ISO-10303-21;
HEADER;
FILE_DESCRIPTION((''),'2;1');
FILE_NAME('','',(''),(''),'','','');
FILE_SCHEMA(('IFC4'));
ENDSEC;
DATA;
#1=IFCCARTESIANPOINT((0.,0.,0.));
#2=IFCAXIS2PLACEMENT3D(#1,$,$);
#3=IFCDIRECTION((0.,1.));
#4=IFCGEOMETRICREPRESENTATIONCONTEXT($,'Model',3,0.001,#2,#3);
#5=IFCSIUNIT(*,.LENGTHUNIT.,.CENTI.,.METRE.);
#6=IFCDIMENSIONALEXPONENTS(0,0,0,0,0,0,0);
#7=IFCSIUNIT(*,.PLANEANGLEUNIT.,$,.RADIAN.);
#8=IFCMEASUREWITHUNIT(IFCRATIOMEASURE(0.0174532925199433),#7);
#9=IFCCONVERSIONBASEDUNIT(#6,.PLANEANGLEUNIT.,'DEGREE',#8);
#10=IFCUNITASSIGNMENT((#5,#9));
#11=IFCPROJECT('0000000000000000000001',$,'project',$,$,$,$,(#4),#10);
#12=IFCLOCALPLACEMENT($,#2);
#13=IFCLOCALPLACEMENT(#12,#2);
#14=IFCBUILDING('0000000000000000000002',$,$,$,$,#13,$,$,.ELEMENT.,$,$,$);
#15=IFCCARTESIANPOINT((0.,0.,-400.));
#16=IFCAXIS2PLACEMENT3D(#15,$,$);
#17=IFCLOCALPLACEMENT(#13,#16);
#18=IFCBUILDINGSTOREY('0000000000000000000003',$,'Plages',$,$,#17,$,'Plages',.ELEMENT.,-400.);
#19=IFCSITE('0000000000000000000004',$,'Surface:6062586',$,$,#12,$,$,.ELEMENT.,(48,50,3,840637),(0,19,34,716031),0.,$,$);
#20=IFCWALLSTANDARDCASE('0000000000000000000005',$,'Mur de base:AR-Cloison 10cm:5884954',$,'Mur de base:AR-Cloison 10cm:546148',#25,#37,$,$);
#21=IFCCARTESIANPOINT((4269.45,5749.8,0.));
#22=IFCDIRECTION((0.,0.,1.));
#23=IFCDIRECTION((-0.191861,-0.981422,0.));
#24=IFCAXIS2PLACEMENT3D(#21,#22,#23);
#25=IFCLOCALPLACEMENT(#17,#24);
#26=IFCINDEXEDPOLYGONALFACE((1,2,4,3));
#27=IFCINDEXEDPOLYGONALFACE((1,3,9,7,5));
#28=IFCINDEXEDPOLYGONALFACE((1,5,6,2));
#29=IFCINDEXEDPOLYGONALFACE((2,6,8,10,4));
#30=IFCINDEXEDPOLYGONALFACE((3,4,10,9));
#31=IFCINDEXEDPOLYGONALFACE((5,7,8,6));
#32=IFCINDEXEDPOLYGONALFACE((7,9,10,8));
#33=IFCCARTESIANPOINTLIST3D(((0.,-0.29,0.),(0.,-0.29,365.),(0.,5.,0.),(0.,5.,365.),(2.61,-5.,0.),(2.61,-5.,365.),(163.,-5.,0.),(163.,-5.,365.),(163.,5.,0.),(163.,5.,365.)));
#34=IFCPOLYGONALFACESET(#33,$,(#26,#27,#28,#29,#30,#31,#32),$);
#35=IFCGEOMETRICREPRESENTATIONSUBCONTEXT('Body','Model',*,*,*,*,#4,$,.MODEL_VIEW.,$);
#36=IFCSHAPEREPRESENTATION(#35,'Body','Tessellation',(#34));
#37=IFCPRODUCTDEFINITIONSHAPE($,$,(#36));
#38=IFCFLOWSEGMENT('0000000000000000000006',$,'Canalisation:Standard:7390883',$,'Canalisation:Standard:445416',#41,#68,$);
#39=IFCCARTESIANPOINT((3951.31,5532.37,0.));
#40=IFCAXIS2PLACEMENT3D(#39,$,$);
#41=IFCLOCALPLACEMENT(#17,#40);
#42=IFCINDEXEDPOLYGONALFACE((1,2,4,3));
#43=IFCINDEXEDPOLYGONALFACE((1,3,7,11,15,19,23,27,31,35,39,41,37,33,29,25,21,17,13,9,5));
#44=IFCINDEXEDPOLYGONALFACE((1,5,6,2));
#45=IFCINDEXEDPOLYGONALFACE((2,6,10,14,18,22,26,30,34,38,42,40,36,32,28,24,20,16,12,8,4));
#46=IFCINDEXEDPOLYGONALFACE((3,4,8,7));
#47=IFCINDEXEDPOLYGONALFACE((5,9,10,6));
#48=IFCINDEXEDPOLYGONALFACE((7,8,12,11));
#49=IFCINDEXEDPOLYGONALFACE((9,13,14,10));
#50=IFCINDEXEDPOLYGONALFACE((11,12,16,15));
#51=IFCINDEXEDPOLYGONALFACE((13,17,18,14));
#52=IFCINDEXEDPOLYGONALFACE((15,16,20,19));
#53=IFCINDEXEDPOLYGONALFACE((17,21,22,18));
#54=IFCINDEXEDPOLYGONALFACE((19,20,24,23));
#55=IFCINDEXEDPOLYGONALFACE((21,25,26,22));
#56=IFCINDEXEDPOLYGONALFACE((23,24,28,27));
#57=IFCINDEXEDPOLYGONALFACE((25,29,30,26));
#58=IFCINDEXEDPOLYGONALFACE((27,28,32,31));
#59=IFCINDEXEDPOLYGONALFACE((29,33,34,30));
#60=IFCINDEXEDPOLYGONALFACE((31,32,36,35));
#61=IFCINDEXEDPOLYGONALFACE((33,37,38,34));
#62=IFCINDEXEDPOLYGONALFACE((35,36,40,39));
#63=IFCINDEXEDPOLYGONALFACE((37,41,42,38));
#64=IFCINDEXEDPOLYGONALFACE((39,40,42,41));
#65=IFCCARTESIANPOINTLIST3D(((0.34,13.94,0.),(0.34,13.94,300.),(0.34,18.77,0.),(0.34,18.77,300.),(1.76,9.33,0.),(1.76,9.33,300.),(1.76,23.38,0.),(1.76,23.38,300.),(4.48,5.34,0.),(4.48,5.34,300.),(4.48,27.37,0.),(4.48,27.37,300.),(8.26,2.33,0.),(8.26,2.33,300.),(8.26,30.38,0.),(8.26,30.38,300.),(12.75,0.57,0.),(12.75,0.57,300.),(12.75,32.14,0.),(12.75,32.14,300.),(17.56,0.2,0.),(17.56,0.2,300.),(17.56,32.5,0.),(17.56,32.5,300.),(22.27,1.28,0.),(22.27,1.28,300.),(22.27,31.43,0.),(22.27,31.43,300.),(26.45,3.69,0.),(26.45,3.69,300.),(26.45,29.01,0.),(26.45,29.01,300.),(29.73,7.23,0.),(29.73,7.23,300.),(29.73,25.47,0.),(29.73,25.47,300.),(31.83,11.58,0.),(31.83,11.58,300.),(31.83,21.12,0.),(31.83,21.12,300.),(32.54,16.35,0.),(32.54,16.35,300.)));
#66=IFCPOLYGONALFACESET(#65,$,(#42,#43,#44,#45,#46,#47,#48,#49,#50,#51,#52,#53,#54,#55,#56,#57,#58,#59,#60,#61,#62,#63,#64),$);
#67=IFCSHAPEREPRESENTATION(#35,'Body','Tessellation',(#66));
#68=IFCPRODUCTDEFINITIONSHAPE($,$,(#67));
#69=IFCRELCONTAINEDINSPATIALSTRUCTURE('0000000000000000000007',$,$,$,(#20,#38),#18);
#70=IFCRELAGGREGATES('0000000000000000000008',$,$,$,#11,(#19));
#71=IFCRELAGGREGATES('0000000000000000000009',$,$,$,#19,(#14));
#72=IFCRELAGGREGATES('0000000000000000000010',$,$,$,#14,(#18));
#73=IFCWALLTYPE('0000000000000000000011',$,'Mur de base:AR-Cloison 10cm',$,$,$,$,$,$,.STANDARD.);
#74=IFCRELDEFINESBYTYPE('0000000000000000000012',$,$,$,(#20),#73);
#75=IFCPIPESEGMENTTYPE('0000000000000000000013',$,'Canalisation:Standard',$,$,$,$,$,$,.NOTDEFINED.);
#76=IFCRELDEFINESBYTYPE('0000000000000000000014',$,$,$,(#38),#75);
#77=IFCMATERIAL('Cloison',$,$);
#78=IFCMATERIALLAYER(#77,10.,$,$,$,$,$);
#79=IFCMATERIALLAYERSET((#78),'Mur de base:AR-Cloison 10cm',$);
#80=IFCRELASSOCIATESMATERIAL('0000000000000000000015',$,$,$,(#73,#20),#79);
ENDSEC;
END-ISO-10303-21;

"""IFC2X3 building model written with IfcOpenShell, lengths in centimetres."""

from ifc_helpers import new_model, entity, si_unit, converted_unit, direction, frame, frame_2d, origin, origin_2d_with_axis, place, context, subcontext, project, spatial, polyline, rectangle, circle, extrude, clip, bounded_halfspace, material, layer, layer_set, layer_usage, type_object, element, save


model = new_model("IFC2X3")

# Units and contexts
model_context = context("Model", 3, precision=0.001, world=origin(), true_north=direction((0.0, 1.0)))
body_context = subcontext(model_context, "Body", "Model", "MODEL_VIEW")
ifc_project = project(units=[si_unit("LENGTHUNIT", "METRE", prefix="CENTI"), converted_unit("PLANEANGLEUNIT", "DEGREE", entity("IfcRatioMeasure", 0.0174532925199433), si_unit("PLANEANGLEUNIT", "RADIAN"), dimensions=[0, 0, 0, 0, 0, 0, 0])], contexts=[model_context])

# Site, building, storey
site_placement = place(None, origin())
site = spatial("IfcSite", under=ifc_project, at=site_placement, Name="Surface:6062586", CompositionType="ELEMENT", RefLatitude=(48, 50, 3, 840637), RefLongitude=(0, 19, 34, 716031), RefElevation=0.0)
building_placement = place(site_placement, origin())
building = spatial("IfcBuilding", under=site, at=building_placement, CompositionType="ELEMENT")
storey_placement = place(building_placement, frame((0.0, 0.0, -400.0)))
storey = spatial("IfcBuildingStorey", under=building, at=storey_placement, Name="Plages", LongName="Plages", CompositionType="ELEMENT", Elevation=-400.0)

# Wall
ifc_material_1 = material(Name="Cloison")
ifc_layer_1 = layer(ifc_material_1, 10.0)
ifc_layer_set_1 = layer_set([ifc_layer_1], Name="Mur de base:AR-Cloison 10cm")
wall_type = type_object("IfcWallType", Name="Mur de base:AR-Cloison 10cm", PredefinedType="STANDARD", material=ifc_layer_set_1)
ifc_layer_usage_1 = layer_usage(ifc_layer_set_1, "AXIS2", "POSITIVE", -5.0)
wall_1_placement = place(storey_placement, frame((4269.45, 5749.8, 0.0), z_axis=(0.0, 0.0, 1.0), x_axis=(-0.191861, -0.981422, 0.0)))
element("IfcWallStandardCase", 1, at=wall_1_placement, inside=storey, type_object=wall_type, material=ifc_layer_usage_1, Name="Mur de base:AR-Cloison 10cm:5884954", ObjectType="Mur de base:AR-Cloison 10cm:546148", context=body_context, shape_type="Clipping", body=[
    clip(extrude(rectangle(XDim=163.0, YDim=10.0, at=frame_2d((81.5, 0.0), x_axis=(-1.0, 0.0))), origin(), (0.0, 0.0, 1.0), 365.0), bounded_halfspace(frame((2.61, -5.0, 0.0), z_axis=(0.874478, 0.485065, 0.0), x_axis=(-0.485065, 0.874478, 0.0)), True, frame((2.61, -5.0, 0.0), z_axis=(0.874478, 0.485065, 0.0), x_axis=(-0.485065, 0.874478, 0.0)), polyline([(0.0, 0.0), (5.38, 0.0), (5.38, 365.0), (0.0, 365.0), (0.0, 0.0)]))),
])

# Flow segment
pipe_segment_type = type_object("IfcPipeSegmentType", Name="Canalisation:Standard", PredefinedType="NOTDEFINED")
flow_segment_placement = place(storey_placement, frame((3951.31, 5532.37, 0.0)))
element("IfcFlowSegment", 2, at=flow_segment_placement, inside=storey, type_object=pipe_segment_type, Name="Canalisation:Standard:7390883", ObjectType="Canalisation:Standard:445416", context=body_context, shape_type="SweptSolid", body=[
    extrude(circle(Radius=16.19, at=origin_2d_with_axis()), frame((16.35, 16.35, 0.0)), (0.0, 0.0, 1.0), 300.0),
])

save(model, "model.ifc")
